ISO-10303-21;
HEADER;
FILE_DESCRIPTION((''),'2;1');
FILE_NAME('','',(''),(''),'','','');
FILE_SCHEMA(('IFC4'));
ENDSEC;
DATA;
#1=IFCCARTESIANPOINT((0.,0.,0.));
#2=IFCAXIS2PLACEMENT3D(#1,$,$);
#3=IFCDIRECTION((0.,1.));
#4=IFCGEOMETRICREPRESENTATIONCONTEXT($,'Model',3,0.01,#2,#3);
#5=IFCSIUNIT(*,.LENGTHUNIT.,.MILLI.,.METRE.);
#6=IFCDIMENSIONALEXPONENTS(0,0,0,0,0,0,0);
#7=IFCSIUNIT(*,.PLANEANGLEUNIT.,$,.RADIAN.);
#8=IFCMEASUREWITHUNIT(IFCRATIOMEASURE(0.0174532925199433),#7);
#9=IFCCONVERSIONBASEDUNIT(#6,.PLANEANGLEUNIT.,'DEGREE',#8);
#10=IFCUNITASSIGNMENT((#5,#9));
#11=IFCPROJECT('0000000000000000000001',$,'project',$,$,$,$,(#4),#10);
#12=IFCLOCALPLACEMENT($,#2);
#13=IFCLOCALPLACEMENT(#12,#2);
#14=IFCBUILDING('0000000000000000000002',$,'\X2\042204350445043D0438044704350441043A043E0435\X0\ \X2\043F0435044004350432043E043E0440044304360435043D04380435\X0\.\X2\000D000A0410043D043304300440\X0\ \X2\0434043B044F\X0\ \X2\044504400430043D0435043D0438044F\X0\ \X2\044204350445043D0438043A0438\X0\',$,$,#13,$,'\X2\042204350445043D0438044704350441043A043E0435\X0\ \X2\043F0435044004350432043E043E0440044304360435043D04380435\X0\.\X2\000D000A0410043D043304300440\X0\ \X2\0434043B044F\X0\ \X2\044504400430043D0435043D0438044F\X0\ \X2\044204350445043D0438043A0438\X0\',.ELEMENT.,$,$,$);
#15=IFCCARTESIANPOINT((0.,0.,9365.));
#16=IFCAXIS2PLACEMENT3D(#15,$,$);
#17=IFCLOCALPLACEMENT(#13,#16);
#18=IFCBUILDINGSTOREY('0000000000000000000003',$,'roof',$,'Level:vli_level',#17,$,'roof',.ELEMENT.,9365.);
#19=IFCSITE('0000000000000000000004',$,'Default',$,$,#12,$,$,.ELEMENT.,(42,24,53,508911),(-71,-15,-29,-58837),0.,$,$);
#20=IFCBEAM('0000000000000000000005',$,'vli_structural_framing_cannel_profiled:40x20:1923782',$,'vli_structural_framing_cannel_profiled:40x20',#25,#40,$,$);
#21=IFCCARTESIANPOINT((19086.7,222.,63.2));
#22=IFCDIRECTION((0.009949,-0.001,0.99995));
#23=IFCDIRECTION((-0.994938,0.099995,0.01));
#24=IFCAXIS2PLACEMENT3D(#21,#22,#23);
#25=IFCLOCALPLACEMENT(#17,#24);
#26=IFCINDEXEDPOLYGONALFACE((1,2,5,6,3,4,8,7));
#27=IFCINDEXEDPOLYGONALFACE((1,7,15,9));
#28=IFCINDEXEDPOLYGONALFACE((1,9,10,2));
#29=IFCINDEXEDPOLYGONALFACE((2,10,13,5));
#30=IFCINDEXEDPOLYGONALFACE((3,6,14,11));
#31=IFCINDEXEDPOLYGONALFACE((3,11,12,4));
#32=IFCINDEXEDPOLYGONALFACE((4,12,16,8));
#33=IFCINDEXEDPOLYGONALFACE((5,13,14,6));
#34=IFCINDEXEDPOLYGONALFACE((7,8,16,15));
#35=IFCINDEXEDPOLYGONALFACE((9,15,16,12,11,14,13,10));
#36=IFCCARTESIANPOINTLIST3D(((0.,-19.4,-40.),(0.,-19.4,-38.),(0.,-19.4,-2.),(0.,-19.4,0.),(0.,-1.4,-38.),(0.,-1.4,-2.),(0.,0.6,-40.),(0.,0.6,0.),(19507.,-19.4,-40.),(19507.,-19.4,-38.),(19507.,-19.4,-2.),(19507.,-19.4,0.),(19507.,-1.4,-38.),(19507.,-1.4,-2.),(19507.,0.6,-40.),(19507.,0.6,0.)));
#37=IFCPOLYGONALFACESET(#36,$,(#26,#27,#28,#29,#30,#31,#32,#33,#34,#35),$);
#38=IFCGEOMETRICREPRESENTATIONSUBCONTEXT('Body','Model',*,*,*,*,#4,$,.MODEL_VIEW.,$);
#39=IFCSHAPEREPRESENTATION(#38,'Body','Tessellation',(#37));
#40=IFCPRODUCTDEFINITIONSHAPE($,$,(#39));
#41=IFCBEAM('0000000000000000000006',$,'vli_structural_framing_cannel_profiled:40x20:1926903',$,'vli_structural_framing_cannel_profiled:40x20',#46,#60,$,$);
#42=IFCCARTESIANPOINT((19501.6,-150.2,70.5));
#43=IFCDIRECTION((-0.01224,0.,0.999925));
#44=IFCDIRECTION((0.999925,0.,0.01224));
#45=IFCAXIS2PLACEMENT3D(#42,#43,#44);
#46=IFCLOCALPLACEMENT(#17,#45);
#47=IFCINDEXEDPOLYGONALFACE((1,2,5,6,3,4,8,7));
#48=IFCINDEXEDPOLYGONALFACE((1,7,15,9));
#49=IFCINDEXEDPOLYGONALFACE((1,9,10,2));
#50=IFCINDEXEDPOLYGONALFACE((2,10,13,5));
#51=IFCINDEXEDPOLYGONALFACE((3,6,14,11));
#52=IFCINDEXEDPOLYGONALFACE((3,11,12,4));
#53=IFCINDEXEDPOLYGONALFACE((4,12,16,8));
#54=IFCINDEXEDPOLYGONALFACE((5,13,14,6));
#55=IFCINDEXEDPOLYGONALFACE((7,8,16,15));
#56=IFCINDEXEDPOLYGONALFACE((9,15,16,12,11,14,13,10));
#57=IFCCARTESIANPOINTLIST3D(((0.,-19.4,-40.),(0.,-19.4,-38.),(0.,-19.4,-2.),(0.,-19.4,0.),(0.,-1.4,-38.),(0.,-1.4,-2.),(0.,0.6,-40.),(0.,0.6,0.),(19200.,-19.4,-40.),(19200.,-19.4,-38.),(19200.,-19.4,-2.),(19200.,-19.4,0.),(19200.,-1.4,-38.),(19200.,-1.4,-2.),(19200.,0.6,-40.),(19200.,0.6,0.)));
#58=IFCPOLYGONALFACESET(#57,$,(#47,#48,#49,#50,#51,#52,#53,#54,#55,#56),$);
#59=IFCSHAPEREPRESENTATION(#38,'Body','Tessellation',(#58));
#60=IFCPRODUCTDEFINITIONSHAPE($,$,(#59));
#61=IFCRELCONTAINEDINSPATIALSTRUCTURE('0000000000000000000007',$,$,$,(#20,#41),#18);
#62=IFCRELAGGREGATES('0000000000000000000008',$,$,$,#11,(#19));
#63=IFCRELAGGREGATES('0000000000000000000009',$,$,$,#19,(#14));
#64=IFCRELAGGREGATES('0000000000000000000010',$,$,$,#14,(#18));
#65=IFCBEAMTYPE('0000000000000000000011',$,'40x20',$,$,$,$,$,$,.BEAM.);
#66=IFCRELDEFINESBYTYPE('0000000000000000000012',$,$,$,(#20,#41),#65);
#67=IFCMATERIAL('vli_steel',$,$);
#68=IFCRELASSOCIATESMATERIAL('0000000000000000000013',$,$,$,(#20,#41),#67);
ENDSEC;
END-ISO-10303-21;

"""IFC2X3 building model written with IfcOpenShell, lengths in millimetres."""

from ifc_helpers import new_model, entity, si_unit, converted_unit, direction, frame, origin, place, context, subcontext, project, spatial, polyline, outline, extrude, material, type_object, element, save


model = new_model("IFC2X3")

# Units and contexts
model_context = context("Model", 3, precision=0.01, world=origin(), true_north=direction((0.0, 1.0)))
body_context = subcontext(model_context, "Body", "Model", "MODEL_VIEW")
ifc_project = project(units=[si_unit("LENGTHUNIT", "METRE", prefix="MILLI"), converted_unit("PLANEANGLEUNIT", "DEGREE", entity("IfcRatioMeasure", 0.0174532925199433), si_unit("PLANEANGLEUNIT", "RADIAN"), dimensions=[0, 0, 0, 0, 0, 0, 0])], contexts=[model_context])

# Site, building, storey
site_placement = place(None, origin())
site = spatial("IfcSite", under=ifc_project, at=site_placement, Name="Default", CompositionType="ELEMENT", RefLatitude=(42, 24, 53, 508911), RefLongitude=(-71, -15, -29, -58837), RefElevation=0.0)
building_placement = place(site_placement, origin())
building = spatial("IfcBuilding", under=site, at=building_placement, Name="Техническое перевооружение.\r\nАнгар для хранения техники", LongName="Техническое перевооружение.\r\nАнгар для хранения техники", CompositionType="ELEMENT")
storey_placement = place(building_placement, frame((0.0, 0.0, 9365.0)))
storey = spatial("IfcBuildingStorey", under=building, at=storey_placement, Name="roof", ObjectType="Level:vli_level", LongName="roof", CompositionType="ELEMENT", Elevation=9365.0)

# Shared definitions
ifc_material = material(Name="vli_steel")
beam_type = type_object("IfcBeamType", Name="40x20", PredefinedType="BEAM")

# Beams
beam_1_placement = place(storey_placement, frame((19086.7, 222.0, 63.2), z_axis=(0.009949, -0.001, 0.99995), x_axis=(-0.994938, 0.099995, 0.01)))
element("IfcBeam", 1, at=beam_1_placement, inside=storey, type_object=beam_type, material=ifc_material, Name="vli_structural_framing_cannel_profiled:40x20:1923782", ObjectType="vli_structural_framing_cannel_profiled:40x20", context=body_context, shape_type="SweptSolid", body=[
    extrude(outline(polyline([(-20.0, -9.5), (-18.0, -9.5), (-18.0, 8.5), (18.0, 8.5), (18.0, -9.5), (20.0, -9.5), (20.0, 10.5), (-20.0, 10.5), (-20.0, -9.5)])), frame((0.0, -9.9, -20.0), z_axis=(1.0, 0.0, 0.0), x_axis=(0.0, 0.0, -1.0)), (0.0, 0.0, 1.0), 19507.0),
])
beam_2_placement = place(storey_placement, frame((19501.6, -150.2, 70.5), z_axis=(-0.01224, 0.0, 0.999925), x_axis=(0.999925, 0.0, 0.01224)))
element("IfcBeam", 2, at=beam_2_placement, inside=storey, type_object=beam_type, material=ifc_material, Name="vli_structural_framing_cannel_profiled:40x20:1926903", ObjectType="vli_structural_framing_cannel_profiled:40x20", context=body_context, shape_type="SweptSolid", body=[
    extrude(outline(polyline([(-20.0, -9.5), (-18.0, -9.5), (-18.0, 8.5), (18.0, 8.5), (18.0, -9.5), (20.0, -9.5), (20.0, 10.5), (-20.0, 10.5), (-20.0, -9.5)])), frame((0.0, -9.9, -20.0), z_axis=(1.0, 0.0, 0.0), x_axis=(0.0, 0.0, -1.0)), (0.0, 0.0, 1.0), 19200.0),
])

save(model, "model.ifc")
